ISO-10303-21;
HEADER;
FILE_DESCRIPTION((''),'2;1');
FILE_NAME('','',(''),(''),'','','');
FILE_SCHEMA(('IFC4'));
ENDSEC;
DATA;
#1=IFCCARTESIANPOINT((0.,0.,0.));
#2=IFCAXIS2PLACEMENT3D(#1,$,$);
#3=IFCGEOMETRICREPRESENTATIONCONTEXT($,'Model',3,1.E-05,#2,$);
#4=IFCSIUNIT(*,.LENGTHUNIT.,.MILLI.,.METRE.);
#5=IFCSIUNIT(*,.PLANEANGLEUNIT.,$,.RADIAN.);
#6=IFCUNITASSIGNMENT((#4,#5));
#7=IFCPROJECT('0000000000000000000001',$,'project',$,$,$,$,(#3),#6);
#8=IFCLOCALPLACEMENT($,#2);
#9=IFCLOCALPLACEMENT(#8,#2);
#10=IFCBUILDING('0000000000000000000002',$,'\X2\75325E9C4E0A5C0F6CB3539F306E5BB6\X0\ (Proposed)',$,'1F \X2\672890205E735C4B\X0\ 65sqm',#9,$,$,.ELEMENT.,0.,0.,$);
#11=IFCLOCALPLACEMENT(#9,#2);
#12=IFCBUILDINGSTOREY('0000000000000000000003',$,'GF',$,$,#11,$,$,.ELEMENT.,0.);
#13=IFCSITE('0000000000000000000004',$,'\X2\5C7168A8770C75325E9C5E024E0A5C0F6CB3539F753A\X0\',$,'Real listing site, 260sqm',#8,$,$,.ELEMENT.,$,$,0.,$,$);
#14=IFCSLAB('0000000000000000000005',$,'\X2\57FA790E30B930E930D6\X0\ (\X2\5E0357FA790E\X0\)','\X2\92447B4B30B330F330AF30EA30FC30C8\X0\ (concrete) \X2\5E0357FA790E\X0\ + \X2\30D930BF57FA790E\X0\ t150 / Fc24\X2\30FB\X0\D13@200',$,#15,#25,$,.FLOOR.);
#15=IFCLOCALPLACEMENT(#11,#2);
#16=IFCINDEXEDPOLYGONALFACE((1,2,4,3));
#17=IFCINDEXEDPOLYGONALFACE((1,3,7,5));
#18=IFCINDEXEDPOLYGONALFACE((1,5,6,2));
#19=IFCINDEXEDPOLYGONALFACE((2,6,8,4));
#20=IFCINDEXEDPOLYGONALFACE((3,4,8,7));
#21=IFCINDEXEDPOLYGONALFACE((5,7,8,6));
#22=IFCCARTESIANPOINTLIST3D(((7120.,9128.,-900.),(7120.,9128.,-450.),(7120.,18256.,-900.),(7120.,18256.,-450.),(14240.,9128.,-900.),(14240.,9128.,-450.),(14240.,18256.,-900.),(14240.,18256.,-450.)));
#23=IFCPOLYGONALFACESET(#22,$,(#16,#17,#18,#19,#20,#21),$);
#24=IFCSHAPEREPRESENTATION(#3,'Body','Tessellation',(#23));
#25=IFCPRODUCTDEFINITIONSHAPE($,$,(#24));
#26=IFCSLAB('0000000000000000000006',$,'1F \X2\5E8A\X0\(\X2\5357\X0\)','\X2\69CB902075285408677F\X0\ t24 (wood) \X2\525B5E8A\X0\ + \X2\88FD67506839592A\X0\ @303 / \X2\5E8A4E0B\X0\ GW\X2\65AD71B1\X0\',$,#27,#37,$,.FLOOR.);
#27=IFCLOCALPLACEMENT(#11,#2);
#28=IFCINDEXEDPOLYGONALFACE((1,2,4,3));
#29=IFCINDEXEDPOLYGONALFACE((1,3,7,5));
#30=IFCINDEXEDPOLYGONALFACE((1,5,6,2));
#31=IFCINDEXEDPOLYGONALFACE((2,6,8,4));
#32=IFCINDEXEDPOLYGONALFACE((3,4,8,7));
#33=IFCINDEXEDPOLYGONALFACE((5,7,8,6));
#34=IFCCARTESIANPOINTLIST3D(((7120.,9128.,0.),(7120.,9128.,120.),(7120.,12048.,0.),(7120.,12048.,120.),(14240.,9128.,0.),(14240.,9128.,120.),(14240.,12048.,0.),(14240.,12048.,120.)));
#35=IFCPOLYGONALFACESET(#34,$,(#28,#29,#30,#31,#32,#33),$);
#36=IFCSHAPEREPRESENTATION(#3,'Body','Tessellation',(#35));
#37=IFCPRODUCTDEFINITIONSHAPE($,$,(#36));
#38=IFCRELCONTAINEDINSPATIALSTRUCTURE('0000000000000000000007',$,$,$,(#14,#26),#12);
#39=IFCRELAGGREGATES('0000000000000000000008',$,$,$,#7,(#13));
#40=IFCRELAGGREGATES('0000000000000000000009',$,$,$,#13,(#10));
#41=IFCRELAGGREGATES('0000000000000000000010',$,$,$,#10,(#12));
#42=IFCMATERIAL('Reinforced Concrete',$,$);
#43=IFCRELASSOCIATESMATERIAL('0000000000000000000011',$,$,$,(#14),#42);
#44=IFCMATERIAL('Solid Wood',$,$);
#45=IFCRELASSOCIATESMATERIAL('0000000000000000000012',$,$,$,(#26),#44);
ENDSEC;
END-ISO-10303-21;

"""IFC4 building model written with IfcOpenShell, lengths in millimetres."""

from ifc_helpers import new_model, si_unit, frame, frame_2d, origin, place, context, project, spatial, rectangle, extrude, material, element, save


model = new_model("IFC4")

# Units and contexts
model_context = context("Model", 3, precision=1e-05, world=origin())
ifc_project = project(units=[si_unit("LENGTHUNIT", "METRE", prefix="MILLI"), si_unit("PLANEANGLEUNIT", "RADIAN")], contexts=[model_context])

# Site, building, storey
site_placement = place(None, origin())
site = spatial("IfcSite", under=ifc_project, at=site_placement, Name="山梨県甲府市上小河原町", ObjectType="Real listing site, 260sqm", CompositionType="ELEMENT", RefElevation=0.0)
building_placement = place(site_placement, origin())
building = spatial("IfcBuilding", under=site, at=building_placement, Name="甲府上小河原の家 (Proposed)", ObjectType="1F 木造平屋 65sqm", CompositionType="ELEMENT", ElevationOfRefHeight=0.0, ElevationOfTerrain=0.0)
storey_placement = place(building_placement, origin())
storey = spatial("IfcBuildingStorey", under=building, at=storey_placement, Name="GF", CompositionType="ELEMENT", Elevation=0.0)

# Shared definitions
ifc_material_1 = material(Name="Solid Wood")

# Slabs
ifc_material_2 = material(Name="Reinforced Concrete")
slab_1_placement = place(storey_placement, frame((3560.0, 4564.0, -450.0)))
element("IfcSlab", 1, at=slab_1_placement, inside=storey, material=ifc_material_2, Name="基礎スラブ (布基礎)", Description="鉄筋コンクリート (concrete) 布基礎 + ベタ基礎 t150 / Fc24・D13@200", PredefinedType="FLOOR", context=model_context, shape_type="SweptSolid", body=[
    extrude(rectangle(XDim=7120.0, YDim=9128.0, at=frame_2d((3560.0, 4564.0))), frame((3560.0, 4564.0, -450.0)), (0.0, 0.0, 1.0), 450.0),
])
slab_2_placement = place(storey_placement, frame((3560.0, 4564.0, 0.0)))
element("IfcSlab", 2, at=slab_2_placement, inside=storey, material=ifc_material_1, Name="1F 床(南)", Description="構造用合板 t24 (wood) 剛床 + 製材根太 @303 / 床下 GW断熱", PredefinedType="FLOOR", context=model_context, shape_type="SweptSolid", body=[
    extrude(rectangle(XDim=7120.0, YDim=2920.0, at=frame_2d((3560.0, 1460.0))), frame((3560.0, 4564.0, 0.0)), (0.0, 0.0, 1.0), 120.0),
])

save(model, "model.ifc")
